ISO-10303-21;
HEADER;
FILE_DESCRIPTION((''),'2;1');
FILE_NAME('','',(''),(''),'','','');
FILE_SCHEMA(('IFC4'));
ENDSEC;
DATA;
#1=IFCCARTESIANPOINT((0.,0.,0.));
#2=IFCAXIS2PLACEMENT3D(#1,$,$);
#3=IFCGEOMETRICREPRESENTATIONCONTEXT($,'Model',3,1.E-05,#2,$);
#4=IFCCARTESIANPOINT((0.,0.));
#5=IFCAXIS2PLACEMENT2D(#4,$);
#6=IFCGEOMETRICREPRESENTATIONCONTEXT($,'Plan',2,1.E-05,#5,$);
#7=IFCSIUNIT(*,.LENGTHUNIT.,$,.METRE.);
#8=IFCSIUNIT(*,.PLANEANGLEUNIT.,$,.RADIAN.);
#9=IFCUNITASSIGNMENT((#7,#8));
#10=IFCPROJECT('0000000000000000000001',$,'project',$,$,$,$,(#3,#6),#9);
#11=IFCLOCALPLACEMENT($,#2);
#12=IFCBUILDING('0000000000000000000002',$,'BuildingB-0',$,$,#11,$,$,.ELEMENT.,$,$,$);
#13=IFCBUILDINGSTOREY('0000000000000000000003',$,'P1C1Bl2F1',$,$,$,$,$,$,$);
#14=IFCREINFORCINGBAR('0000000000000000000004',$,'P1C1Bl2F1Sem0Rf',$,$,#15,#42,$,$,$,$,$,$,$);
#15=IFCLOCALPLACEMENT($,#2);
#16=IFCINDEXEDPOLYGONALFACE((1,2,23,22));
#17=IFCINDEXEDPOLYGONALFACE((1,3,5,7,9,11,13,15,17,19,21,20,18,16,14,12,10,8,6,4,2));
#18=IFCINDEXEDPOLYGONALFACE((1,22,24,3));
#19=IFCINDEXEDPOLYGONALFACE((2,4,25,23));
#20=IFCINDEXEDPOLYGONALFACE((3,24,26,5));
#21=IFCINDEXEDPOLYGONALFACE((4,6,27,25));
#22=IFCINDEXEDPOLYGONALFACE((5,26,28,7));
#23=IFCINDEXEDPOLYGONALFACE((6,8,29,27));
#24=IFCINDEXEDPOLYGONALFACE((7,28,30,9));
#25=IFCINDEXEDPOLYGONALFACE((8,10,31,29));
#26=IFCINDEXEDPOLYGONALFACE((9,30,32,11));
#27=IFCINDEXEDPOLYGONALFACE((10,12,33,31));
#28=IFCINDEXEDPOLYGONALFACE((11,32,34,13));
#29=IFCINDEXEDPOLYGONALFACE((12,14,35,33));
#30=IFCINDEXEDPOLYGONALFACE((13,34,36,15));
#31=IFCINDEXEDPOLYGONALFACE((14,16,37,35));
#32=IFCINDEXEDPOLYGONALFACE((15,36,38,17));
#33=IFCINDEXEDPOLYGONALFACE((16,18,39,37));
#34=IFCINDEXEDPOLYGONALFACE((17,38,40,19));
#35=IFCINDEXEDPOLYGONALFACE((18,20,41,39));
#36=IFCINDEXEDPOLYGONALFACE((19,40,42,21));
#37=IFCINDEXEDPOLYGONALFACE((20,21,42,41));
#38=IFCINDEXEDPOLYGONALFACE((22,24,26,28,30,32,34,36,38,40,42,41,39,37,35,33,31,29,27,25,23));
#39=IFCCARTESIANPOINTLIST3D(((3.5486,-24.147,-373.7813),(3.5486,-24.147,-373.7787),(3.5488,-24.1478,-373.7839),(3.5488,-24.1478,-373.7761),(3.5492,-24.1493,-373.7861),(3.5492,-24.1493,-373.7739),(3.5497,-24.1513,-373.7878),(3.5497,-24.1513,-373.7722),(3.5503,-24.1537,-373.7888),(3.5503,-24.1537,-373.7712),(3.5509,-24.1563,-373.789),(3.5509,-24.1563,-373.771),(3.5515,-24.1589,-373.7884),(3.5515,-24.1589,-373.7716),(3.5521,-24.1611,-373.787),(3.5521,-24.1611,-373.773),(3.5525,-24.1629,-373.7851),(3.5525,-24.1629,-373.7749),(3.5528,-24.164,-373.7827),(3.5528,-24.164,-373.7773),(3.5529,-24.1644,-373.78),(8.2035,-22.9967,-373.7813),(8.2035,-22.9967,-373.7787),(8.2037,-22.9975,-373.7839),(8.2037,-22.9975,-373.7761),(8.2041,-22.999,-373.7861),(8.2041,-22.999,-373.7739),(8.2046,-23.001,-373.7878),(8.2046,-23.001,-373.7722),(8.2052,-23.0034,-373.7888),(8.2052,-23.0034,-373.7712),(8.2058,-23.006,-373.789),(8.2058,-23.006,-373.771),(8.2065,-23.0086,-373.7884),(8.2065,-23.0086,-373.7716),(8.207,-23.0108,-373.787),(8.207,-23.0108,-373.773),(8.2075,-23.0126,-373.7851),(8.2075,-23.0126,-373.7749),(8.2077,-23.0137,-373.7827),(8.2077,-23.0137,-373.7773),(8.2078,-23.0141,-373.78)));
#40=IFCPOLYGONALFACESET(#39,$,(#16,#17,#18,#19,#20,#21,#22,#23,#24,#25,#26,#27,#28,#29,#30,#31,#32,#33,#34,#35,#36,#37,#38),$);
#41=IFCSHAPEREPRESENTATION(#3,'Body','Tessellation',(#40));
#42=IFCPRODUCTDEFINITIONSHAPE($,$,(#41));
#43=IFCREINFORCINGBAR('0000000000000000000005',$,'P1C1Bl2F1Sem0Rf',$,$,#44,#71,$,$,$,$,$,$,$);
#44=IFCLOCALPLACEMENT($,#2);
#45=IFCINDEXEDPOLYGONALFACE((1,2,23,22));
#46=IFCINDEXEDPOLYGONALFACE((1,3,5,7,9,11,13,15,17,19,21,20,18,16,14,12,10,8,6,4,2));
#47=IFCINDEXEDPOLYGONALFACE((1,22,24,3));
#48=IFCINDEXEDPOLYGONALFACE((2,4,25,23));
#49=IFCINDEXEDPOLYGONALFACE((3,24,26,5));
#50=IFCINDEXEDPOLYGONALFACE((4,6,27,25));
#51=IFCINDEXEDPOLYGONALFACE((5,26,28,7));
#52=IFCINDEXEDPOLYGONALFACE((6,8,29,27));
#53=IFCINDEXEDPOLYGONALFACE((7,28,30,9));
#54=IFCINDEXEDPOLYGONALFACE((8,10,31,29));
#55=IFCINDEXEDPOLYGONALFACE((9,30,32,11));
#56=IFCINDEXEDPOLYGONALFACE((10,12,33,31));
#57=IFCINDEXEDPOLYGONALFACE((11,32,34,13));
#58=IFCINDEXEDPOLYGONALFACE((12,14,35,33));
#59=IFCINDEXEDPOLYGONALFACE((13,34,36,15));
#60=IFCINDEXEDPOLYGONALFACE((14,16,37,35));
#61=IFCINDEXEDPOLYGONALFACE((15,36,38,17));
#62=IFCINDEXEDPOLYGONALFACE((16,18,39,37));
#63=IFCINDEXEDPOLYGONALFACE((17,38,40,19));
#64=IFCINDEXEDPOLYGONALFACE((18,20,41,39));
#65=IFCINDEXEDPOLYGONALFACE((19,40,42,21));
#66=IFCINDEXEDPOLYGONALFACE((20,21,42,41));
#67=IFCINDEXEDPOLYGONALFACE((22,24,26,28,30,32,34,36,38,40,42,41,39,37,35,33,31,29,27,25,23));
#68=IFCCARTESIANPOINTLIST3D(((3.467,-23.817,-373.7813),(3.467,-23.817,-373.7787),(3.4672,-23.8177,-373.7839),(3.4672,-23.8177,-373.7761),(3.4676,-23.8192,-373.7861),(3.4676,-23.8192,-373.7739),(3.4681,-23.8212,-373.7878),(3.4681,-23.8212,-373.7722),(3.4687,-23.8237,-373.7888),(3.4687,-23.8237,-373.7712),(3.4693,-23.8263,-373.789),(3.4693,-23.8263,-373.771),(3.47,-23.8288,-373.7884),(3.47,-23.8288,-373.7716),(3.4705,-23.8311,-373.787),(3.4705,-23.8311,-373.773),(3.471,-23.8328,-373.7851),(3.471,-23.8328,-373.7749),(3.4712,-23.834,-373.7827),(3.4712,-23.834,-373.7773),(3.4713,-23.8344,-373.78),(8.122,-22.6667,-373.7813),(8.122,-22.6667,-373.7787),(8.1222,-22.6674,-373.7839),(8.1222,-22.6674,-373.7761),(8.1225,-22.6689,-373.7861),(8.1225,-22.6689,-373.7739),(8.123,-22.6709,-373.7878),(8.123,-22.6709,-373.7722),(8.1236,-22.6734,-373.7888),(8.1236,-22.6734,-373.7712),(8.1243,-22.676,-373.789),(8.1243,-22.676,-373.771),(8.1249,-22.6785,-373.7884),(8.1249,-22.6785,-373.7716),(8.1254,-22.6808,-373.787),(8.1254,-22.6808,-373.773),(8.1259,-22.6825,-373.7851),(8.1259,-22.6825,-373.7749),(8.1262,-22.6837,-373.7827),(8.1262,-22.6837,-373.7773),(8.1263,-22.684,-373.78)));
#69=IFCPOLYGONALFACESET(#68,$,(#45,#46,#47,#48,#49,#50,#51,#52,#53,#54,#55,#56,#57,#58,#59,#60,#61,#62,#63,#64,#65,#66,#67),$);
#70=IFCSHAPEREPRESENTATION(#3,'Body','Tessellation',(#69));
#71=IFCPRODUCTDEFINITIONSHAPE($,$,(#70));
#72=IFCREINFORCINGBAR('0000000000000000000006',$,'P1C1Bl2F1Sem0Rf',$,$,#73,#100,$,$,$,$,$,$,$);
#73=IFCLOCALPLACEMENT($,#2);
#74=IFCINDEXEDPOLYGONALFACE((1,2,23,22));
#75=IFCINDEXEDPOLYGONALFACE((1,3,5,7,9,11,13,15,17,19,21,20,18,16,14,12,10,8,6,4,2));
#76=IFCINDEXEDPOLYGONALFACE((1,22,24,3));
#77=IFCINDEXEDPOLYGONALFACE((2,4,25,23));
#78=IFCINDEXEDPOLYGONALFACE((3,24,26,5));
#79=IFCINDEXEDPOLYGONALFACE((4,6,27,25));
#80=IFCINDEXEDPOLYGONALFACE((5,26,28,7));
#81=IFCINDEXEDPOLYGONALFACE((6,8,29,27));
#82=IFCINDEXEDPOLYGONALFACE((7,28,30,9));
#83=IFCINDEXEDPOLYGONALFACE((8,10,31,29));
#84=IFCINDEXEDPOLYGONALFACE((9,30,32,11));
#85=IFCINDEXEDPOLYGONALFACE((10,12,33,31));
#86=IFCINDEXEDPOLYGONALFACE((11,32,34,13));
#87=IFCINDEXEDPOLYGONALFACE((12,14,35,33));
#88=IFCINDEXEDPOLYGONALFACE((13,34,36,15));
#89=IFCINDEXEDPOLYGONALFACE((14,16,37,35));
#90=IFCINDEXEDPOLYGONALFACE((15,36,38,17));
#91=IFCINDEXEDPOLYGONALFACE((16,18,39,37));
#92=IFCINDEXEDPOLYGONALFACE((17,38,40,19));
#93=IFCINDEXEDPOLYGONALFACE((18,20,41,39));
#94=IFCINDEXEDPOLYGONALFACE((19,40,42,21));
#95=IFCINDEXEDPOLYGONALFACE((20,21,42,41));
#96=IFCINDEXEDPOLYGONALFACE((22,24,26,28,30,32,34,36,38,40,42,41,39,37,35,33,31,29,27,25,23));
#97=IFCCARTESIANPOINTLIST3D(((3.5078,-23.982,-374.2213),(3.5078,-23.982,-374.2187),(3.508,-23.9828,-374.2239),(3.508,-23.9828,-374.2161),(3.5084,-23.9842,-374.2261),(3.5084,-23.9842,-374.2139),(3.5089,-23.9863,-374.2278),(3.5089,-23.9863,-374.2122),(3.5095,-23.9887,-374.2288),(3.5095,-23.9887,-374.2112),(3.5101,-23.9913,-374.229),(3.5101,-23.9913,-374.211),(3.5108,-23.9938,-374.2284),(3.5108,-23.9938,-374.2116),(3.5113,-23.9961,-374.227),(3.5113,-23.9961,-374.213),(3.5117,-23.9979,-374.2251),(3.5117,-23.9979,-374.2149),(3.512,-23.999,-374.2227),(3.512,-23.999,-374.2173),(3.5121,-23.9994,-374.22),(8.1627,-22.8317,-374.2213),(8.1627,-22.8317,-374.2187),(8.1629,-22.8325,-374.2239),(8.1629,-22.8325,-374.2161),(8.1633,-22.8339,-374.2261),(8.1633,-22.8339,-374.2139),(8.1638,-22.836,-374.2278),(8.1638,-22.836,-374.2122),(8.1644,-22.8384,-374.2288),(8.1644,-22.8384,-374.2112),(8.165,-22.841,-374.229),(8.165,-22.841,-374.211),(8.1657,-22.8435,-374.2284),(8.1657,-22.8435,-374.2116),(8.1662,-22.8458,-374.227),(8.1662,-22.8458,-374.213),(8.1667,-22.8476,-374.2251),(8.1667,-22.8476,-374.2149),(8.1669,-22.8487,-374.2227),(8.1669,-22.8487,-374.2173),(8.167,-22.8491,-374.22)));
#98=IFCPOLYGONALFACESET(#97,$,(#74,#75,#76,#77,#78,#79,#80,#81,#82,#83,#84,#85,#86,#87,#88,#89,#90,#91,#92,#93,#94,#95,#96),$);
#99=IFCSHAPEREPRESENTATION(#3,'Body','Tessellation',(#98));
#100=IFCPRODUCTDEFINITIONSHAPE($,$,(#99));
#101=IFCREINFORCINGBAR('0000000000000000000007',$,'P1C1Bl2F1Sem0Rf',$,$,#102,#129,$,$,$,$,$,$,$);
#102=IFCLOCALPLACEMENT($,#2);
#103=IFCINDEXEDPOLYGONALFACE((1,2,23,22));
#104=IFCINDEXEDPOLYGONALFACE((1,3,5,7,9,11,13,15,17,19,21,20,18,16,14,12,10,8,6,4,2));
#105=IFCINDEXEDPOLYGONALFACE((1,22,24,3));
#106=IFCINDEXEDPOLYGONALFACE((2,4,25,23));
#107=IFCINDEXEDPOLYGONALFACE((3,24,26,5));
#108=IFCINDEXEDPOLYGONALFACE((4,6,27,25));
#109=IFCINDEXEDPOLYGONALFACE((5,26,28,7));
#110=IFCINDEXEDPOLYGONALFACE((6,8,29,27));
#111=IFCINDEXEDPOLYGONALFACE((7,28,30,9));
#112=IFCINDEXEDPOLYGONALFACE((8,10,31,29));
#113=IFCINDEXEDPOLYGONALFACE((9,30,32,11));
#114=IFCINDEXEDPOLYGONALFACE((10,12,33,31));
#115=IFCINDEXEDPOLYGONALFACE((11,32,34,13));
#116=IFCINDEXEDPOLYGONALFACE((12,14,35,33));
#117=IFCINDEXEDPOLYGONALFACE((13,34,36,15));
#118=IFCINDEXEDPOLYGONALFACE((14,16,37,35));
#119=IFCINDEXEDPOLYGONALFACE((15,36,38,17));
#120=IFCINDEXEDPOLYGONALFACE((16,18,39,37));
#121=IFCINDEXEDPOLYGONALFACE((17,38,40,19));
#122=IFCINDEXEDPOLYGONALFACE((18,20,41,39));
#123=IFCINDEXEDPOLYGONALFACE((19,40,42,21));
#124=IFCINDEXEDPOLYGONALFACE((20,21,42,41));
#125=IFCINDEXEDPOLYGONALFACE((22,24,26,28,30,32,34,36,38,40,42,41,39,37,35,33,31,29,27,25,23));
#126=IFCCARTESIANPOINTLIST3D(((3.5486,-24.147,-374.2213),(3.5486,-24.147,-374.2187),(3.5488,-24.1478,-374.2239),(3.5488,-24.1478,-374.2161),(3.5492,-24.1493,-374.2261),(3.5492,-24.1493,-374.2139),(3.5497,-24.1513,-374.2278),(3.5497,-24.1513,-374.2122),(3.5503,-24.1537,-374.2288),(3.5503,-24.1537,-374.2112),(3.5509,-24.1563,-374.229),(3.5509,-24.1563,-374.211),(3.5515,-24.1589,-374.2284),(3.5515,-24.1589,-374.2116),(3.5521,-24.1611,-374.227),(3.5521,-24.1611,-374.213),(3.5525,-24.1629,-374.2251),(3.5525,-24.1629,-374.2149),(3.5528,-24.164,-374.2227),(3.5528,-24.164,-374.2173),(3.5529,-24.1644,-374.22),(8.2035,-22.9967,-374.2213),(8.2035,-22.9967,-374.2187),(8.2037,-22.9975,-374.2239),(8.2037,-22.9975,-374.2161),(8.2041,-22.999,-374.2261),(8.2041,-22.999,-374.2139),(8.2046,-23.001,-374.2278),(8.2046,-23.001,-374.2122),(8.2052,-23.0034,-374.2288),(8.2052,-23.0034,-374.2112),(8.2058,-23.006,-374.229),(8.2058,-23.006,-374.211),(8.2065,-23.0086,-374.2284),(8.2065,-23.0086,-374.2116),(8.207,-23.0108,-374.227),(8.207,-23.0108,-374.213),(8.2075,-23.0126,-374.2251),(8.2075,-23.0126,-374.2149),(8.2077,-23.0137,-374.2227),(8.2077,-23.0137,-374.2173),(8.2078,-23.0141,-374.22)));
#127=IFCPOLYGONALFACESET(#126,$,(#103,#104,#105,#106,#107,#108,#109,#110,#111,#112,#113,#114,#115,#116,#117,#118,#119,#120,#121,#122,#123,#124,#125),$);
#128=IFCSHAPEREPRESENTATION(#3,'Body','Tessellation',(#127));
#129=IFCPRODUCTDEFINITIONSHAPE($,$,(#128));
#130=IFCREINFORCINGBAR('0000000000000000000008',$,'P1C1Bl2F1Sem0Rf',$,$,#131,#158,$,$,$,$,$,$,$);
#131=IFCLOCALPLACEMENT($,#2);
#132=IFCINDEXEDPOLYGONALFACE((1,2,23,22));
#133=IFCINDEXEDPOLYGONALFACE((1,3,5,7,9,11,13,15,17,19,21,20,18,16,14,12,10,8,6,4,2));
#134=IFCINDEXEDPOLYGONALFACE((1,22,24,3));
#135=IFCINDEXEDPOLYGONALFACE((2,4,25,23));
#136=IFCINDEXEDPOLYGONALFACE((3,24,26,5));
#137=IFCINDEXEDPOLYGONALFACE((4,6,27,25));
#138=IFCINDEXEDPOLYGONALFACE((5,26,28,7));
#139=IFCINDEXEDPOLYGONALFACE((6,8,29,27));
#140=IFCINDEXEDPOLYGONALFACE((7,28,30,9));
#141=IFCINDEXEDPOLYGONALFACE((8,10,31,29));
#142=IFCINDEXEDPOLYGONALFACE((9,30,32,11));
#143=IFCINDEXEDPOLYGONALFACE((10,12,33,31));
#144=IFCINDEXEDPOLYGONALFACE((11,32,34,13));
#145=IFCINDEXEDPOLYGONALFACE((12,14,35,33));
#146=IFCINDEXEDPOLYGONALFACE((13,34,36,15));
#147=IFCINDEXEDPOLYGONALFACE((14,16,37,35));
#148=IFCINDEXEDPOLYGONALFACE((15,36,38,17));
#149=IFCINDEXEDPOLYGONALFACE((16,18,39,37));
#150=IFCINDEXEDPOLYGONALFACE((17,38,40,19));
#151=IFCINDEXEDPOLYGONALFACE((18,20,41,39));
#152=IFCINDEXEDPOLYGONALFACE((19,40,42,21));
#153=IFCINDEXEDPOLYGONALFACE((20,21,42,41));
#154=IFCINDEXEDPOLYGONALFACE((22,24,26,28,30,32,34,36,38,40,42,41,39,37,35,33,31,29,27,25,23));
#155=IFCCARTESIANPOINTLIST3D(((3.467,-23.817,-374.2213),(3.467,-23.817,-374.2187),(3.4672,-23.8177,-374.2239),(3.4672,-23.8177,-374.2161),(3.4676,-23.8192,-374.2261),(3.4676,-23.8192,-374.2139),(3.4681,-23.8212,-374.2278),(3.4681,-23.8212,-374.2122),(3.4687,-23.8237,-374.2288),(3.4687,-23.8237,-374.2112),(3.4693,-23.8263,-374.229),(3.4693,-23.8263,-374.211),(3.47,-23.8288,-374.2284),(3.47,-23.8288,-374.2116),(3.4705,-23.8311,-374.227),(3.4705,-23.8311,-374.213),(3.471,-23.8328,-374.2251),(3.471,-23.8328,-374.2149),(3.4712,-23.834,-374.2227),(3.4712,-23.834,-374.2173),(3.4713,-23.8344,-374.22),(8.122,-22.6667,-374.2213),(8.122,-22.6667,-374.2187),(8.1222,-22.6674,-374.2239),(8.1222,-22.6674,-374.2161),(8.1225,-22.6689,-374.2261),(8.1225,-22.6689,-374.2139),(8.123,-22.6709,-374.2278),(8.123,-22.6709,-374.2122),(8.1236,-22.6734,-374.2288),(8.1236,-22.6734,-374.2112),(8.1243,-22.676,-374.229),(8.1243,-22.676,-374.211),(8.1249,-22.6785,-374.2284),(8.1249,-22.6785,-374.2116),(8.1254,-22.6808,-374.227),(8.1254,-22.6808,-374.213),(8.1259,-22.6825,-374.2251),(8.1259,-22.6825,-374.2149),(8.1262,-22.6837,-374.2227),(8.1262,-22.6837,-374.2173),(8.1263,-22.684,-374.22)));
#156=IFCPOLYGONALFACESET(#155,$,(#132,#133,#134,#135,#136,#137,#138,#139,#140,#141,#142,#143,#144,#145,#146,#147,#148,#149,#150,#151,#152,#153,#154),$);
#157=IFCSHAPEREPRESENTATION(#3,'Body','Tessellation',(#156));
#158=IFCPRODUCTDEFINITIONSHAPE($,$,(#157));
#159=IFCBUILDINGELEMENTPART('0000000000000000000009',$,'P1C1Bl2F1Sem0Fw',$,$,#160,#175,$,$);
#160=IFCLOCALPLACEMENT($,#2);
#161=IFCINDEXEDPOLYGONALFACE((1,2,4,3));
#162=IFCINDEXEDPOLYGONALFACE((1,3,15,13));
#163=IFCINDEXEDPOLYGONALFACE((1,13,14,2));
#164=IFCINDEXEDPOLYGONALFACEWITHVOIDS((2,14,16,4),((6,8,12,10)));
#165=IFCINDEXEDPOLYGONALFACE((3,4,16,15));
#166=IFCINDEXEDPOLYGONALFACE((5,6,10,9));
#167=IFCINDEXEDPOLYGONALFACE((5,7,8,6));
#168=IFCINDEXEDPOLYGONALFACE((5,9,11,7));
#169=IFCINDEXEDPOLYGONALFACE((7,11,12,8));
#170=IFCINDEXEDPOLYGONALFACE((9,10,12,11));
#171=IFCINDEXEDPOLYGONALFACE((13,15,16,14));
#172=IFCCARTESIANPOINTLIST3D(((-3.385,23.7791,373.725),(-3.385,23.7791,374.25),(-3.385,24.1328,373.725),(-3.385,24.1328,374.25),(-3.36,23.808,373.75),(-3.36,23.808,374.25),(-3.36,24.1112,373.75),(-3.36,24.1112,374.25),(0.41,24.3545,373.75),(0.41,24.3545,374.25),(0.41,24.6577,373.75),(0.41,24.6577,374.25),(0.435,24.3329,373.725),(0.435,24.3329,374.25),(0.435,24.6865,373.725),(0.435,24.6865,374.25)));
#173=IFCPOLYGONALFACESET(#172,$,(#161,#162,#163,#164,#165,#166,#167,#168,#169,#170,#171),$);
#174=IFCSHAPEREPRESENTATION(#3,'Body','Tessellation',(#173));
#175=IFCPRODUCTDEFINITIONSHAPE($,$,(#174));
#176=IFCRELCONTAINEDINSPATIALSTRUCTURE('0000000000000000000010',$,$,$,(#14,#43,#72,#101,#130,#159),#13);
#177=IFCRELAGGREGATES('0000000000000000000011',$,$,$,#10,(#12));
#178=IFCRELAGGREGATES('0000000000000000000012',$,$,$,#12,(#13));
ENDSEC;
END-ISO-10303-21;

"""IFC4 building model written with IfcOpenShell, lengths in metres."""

from ifc_helpers import new_model, entity, si_unit, origin, origin_2d, place, context, project, spatial, polyline, outline, extrude, element, save


model = new_model("IFC4")

# Units and contexts
model_context = context("Model", 3, precision=1e-05, world=origin())
plan_context = context("Plan", 2, precision=1e-05, world=origin_2d())
ifc_project = project(units=[si_unit("LENGTHUNIT", "METRE"), si_unit("PLANEANGLEUNIT", "RADIAN")], contexts=[model_context, plan_context])

# Building, storey
building_placement = place(None, origin())
building = spatial("IfcBuilding", under=ifc_project, at=building_placement, Name="BuildingB-0", CompositionType="ELEMENT")
storey = spatial("IfcBuildingStorey", under=building, Name="P1C1Bl2F1")

# Reinforcing bars
element("IfcReinforcingBar", 1, inside=storey, Name="P1C1Bl2F1Sem0Rf", context=model_context, shape_type="SweptSolid", body=[
    entity("IfcSurfaceCurveSweptAreaSolid", entity("IfcCircleProfileDef", "AREA", None, None, 0.009), None, entity("IfcPolyline", [entity("IfcCartesianPoint", [-3.5507, 24.1557, 373.78]), entity("IfcCartesianPoint", [-8.2057, 23.0054, 373.78])]), None, None, entity("IfcPlane", entity("IfcAxis2Placement3D", entity("IfcCartesianPoint", [-3.5507, 24.1557, 373.78]), entity("IfcDirection", [0.0, 0.0, 1.0]), entity("IfcDirection", [1.0, 0.0, 0.0])))),
])
element("IfcReinforcingBar", 2, inside=storey, Name="P1C1Bl2F1Sem0Rf", context=model_context, shape_type="SweptSolid", body=[
    entity("IfcSurfaceCurveSweptAreaSolid", entity("IfcCircleProfileDef", "AREA", None, None, 0.009), None, entity("IfcPolyline", [entity("IfcCartesianPoint", [-3.4692, 23.8256, 373.78]), entity("IfcCartesianPoint", [-8.1241, 22.6753, 373.78])]), None, None, entity("IfcPlane", entity("IfcAxis2Placement3D", entity("IfcCartesianPoint", [-3.4692, 23.8256, 373.78]), entity("IfcDirection", [0.0, 0.0, 1.0]), entity("IfcDirection", [1.0, 0.0, 0.0])))),
])
element("IfcReinforcingBar", 3, inside=storey, Name="P1C1Bl2F1Sem0Rf", context=model_context, shape_type="SweptSolid", body=[
    entity("IfcSurfaceCurveSweptAreaSolid", entity("IfcCircleProfileDef", "AREA", None, None, 0.009), None, entity("IfcPolyline", [entity("IfcCartesianPoint", [-3.51, 23.9907, 374.22]), entity("IfcCartesianPoint", [-8.1649, 22.8403, 374.22])]), None, None, entity("IfcPlane", entity("IfcAxis2Placement3D", entity("IfcCartesianPoint", [-3.51, 23.9907, 374.22]), entity("IfcDirection", [0.0, 0.0, 1.0]), entity("IfcDirection", [1.0, 0.0, 0.0])))),
])
element("IfcReinforcingBar", 4, inside=storey, Name="P1C1Bl2F1Sem0Rf", context=model_context, shape_type="SweptSolid", body=[
    entity("IfcSurfaceCurveSweptAreaSolid", entity("IfcCircleProfileDef", "AREA", None, None, 0.009), None, entity("IfcPolyline", [entity("IfcCartesianPoint", [-3.5507, 24.1557, 374.22]), entity("IfcCartesianPoint", [-8.2057, 23.0054, 374.22])]), None, None, entity("IfcPlane", entity("IfcAxis2Placement3D", entity("IfcCartesianPoint", [-3.5507, 24.1557, 374.22]), entity("IfcDirection", [0.0, 0.0, 1.0]), entity("IfcDirection", [1.0, 0.0, 0.0])))),
])
element("IfcReinforcingBar", 5, inside=storey, Name="P1C1Bl2F1Sem0Rf", context=model_context, shape_type="SweptSolid", body=[
    entity("IfcSurfaceCurveSweptAreaSolid", entity("IfcCircleProfileDef", "AREA", None, None, 0.009), None, entity("IfcPolyline", [entity("IfcCartesianPoint", [-3.4692, 23.8256, 374.22]), entity("IfcCartesianPoint", [-8.1241, 22.6753, 374.22])]), None, None, entity("IfcPlane", entity("IfcAxis2Placement3D", entity("IfcCartesianPoint", [-3.4692, 23.8256, 374.22]), entity("IfcDirection", [0.0, 0.0, 1.0]), entity("IfcDirection", [1.0, 0.0, 0.0])))),
])

# Building element part, opening
building_element_part_1 = element("IfcBuildingElementPart", 6, inside=storey, Name="P1C1Bl2F1Sem0Fw", context=model_context, shape_type="SweptSolid", body=[
    extrude(outline(polyline([(-3.385, 23.7791, 373.725), (0.435, 24.3329, 373.725), (0.435, 24.6865, 373.725), (-3.385, 24.1328, 373.725), (-3.385, 23.7791, 373.725)])), None, (0.0, 0.0, 1.0), 0.525),
])
element("IfcOpeningElement", 7, inside=storey, cuts=building_element_part_1, context=model_context, shape_type="SweptSolid", body=[
    extrude(outline(polyline([(-3.36, 23.808, 373.75), (0.41, 24.3545, 373.75), (0.41, 24.6577, 373.75), (-3.36, 24.1112, 373.75), (-3.36, 23.808, 373.75)])), None, (0.0, 0.0, 1.0), 0.5),
])

save(model, "model.ifc")
